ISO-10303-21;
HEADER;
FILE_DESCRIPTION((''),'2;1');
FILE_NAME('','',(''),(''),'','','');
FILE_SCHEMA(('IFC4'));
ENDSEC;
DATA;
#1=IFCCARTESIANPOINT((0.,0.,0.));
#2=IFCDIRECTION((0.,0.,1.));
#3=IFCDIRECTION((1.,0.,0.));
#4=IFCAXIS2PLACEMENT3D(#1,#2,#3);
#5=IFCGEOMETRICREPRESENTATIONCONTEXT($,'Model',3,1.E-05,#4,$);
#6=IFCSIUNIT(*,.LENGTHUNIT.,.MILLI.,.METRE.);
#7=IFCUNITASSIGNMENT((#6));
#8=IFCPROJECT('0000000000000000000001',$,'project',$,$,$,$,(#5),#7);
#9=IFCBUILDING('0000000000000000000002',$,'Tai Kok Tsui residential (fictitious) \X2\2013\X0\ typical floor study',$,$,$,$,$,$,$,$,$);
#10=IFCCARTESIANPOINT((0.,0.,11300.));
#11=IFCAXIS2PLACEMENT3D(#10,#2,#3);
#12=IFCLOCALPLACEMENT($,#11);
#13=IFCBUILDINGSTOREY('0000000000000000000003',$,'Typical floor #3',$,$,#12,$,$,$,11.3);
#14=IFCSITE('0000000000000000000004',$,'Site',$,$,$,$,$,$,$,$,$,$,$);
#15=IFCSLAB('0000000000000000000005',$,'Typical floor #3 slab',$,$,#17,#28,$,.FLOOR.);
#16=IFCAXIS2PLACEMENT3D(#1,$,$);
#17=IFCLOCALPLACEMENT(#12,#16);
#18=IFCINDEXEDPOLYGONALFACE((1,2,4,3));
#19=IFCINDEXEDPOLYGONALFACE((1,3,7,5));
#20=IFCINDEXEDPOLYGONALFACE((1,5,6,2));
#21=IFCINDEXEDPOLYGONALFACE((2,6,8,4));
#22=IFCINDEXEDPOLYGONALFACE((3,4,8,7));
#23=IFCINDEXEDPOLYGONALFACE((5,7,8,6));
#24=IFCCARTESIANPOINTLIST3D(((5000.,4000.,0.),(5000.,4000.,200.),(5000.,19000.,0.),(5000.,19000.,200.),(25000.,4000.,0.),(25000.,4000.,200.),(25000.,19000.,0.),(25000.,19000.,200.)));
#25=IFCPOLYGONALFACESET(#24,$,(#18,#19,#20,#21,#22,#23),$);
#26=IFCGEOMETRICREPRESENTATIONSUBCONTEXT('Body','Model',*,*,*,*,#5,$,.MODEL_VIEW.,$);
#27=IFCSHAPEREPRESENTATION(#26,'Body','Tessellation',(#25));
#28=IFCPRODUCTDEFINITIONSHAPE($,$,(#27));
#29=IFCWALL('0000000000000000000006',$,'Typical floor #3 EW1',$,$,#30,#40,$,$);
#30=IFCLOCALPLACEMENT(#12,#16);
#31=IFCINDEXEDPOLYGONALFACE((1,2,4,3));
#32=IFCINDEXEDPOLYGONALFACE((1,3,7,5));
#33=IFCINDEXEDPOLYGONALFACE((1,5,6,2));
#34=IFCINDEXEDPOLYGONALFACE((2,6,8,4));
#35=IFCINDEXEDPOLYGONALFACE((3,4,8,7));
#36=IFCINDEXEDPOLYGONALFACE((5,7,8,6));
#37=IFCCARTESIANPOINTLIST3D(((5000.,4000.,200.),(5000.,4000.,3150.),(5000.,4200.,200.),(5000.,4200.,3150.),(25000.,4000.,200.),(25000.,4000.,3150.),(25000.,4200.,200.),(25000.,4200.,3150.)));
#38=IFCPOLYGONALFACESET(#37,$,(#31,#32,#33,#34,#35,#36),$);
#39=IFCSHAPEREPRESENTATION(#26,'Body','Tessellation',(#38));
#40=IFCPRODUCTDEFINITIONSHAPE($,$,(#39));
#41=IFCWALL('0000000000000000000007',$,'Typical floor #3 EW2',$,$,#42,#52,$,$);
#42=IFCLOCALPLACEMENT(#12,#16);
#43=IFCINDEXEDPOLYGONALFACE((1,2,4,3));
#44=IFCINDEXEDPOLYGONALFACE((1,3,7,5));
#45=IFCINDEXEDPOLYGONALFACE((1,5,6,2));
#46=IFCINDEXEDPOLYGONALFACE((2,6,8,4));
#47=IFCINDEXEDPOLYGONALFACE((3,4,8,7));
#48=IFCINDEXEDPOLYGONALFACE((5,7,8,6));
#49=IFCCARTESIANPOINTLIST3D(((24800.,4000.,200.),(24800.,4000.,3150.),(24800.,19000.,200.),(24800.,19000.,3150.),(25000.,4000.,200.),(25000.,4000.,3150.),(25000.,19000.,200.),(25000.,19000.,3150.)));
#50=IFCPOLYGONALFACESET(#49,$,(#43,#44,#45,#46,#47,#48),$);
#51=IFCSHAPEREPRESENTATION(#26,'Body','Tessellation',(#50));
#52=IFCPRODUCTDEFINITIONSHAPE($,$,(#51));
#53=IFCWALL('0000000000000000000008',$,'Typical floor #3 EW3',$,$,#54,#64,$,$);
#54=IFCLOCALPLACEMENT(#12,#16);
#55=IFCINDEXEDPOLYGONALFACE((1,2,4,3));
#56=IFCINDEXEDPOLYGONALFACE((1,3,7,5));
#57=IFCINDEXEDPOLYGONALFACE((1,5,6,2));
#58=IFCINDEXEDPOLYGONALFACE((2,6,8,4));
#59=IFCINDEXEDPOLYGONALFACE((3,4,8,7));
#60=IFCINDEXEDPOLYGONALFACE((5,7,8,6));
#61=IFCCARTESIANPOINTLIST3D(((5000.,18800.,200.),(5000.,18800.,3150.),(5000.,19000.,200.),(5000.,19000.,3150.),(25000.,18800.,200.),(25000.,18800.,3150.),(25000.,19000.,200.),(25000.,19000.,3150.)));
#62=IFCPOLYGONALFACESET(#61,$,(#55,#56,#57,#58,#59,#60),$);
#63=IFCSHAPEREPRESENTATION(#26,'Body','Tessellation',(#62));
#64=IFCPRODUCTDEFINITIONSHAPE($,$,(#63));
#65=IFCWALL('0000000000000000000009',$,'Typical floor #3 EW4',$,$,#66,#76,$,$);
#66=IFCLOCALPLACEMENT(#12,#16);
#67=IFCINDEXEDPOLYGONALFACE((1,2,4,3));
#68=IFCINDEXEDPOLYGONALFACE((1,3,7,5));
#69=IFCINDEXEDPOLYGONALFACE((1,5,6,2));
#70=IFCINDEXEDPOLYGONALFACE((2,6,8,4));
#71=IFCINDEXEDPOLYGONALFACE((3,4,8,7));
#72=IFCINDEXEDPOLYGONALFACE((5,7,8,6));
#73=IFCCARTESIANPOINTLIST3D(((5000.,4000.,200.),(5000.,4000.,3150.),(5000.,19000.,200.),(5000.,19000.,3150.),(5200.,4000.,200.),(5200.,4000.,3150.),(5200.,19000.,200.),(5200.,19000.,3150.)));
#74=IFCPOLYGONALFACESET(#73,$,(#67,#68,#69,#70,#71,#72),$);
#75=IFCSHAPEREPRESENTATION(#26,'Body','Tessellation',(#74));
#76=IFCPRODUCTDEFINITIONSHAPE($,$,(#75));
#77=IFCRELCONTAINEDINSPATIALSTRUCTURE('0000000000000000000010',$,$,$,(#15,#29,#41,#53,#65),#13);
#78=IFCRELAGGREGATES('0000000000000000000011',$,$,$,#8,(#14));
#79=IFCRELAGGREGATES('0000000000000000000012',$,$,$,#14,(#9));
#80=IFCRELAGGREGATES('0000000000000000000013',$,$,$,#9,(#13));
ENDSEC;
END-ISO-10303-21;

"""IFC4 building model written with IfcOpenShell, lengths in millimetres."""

from ifc_helpers import new_model, si_unit, frame, origin_with_axes, place, context, subcontext, project, spatial, indexed_curve, outline, extrude, element, save


model = new_model("IFC4")

# Units and contexts
model_context = context("Model", 3, precision=1e-05, world=origin_with_axes())
body_context = subcontext(model_context, "Body", "Model", "MODEL_VIEW")
ifc_project = project(units=[si_unit("LENGTHUNIT", "METRE", prefix="MILLI")], contexts=[model_context])

# Site, building, storey
site = spatial("IfcSite", under=ifc_project, Name="Site")
building = spatial("IfcBuilding", under=site, Name="Tai Kok Tsui residential (fictitious) – typical floor study")
storey_placement = place(None, frame((0.0, 0.0, 11300.0), z_axis=(0.0, 0.0, 1.0), x_axis=(1.0, 0.0, 0.0)))
storey = spatial("IfcBuildingStorey", under=building, at=storey_placement, Name="Typical floor #3", Elevation=11.3)

# Slab
slab_placement = place(storey_placement, origin_with_axes())
element("IfcSlab", 1, at=slab_placement, inside=storey, Name="Typical floor #3 slab", PredefinedType="FLOOR", context=body_context, shape_type="SweptSolid", body=[
    extrude(outline(indexed_curve([(5000.0, 4000.0), (25000.0, 4000.0), (25000.0, 19000.0), (5000.0, 19000.0)])), None, (0.0, 0.0, 1.0), 200.0),
])

# Walls
wall_1_placement = place(storey_placement, frame((5000.0, 4000.0, 200.0), z_axis=(0.0, 0.0, 1.0), x_axis=(1.0, 0.0, 0.0)))
element("IfcWall", 2, at=wall_1_placement, inside=storey, Name="Typical floor #3 EW1", context=body_context, shape_type="SweptSolid", body=[
    extrude(outline(indexed_curve([(0.0, 0.0), (0.0, 200.0), (20000.0, 200.0), (20000.0, 0.0), (0.0, 0.0)], self_intersect=False)), origin_with_axes(), (0.0, 0.0, 1.0), 2950.0),
])
wall_2_placement = place(storey_placement, frame((25000.0, 4000.0, 200.0), z_axis=(0.0, 0.0, 1.0), x_axis=(0.0, 1.0, 0.0)))
element("IfcWall", 3, at=wall_2_placement, inside=storey, Name="Typical floor #3 EW2", context=body_context, shape_type="SweptSolid", body=[
    extrude(outline(indexed_curve([(0.0, 0.0), (0.0, 200.0), (15000.0, 200.0), (15000.0, 0.0), (0.0, 0.0)], self_intersect=False)), origin_with_axes(), (0.0, 0.0, 1.0), 2950.0),
])
wall_3_placement = place(storey_placement, frame((25000.0, 19000.0, 200.0), z_axis=(0.0, 0.0, 1.0), x_axis=(-1.0, 0.0, 0.0)))
element("IfcWall", 4, at=wall_3_placement, inside=storey, Name="Typical floor #3 EW3", context=body_context, shape_type="SweptSolid", body=[
    extrude(outline(indexed_curve([(0.0, 0.0), (0.0, 200.0), (20000.0, 200.0), (20000.0, 0.0), (0.0, 0.0)], self_intersect=False)), origin_with_axes(), (0.0, 0.0, 1.0), 2950.0),
])
wall_4_placement = place(storey_placement, frame((5000.0, 19000.0, 200.0), z_axis=(0.0, 0.0, 1.0), x_axis=(0.0, -1.0, 0.0)))
element("IfcWall", 5, at=wall_4_placement, inside=storey, Name="Typical floor #3 EW4", context=body_context, shape_type="SweptSolid", body=[
    extrude(outline(indexed_curve([(0.0, 0.0), (0.0, 200.0), (15000.0, 200.0), (15000.0, 0.0), (0.0, 0.0)], self_intersect=False)), origin_with_axes(), (0.0, 0.0, 1.0), 2950.0),
])

save(model, "model.ifc")
